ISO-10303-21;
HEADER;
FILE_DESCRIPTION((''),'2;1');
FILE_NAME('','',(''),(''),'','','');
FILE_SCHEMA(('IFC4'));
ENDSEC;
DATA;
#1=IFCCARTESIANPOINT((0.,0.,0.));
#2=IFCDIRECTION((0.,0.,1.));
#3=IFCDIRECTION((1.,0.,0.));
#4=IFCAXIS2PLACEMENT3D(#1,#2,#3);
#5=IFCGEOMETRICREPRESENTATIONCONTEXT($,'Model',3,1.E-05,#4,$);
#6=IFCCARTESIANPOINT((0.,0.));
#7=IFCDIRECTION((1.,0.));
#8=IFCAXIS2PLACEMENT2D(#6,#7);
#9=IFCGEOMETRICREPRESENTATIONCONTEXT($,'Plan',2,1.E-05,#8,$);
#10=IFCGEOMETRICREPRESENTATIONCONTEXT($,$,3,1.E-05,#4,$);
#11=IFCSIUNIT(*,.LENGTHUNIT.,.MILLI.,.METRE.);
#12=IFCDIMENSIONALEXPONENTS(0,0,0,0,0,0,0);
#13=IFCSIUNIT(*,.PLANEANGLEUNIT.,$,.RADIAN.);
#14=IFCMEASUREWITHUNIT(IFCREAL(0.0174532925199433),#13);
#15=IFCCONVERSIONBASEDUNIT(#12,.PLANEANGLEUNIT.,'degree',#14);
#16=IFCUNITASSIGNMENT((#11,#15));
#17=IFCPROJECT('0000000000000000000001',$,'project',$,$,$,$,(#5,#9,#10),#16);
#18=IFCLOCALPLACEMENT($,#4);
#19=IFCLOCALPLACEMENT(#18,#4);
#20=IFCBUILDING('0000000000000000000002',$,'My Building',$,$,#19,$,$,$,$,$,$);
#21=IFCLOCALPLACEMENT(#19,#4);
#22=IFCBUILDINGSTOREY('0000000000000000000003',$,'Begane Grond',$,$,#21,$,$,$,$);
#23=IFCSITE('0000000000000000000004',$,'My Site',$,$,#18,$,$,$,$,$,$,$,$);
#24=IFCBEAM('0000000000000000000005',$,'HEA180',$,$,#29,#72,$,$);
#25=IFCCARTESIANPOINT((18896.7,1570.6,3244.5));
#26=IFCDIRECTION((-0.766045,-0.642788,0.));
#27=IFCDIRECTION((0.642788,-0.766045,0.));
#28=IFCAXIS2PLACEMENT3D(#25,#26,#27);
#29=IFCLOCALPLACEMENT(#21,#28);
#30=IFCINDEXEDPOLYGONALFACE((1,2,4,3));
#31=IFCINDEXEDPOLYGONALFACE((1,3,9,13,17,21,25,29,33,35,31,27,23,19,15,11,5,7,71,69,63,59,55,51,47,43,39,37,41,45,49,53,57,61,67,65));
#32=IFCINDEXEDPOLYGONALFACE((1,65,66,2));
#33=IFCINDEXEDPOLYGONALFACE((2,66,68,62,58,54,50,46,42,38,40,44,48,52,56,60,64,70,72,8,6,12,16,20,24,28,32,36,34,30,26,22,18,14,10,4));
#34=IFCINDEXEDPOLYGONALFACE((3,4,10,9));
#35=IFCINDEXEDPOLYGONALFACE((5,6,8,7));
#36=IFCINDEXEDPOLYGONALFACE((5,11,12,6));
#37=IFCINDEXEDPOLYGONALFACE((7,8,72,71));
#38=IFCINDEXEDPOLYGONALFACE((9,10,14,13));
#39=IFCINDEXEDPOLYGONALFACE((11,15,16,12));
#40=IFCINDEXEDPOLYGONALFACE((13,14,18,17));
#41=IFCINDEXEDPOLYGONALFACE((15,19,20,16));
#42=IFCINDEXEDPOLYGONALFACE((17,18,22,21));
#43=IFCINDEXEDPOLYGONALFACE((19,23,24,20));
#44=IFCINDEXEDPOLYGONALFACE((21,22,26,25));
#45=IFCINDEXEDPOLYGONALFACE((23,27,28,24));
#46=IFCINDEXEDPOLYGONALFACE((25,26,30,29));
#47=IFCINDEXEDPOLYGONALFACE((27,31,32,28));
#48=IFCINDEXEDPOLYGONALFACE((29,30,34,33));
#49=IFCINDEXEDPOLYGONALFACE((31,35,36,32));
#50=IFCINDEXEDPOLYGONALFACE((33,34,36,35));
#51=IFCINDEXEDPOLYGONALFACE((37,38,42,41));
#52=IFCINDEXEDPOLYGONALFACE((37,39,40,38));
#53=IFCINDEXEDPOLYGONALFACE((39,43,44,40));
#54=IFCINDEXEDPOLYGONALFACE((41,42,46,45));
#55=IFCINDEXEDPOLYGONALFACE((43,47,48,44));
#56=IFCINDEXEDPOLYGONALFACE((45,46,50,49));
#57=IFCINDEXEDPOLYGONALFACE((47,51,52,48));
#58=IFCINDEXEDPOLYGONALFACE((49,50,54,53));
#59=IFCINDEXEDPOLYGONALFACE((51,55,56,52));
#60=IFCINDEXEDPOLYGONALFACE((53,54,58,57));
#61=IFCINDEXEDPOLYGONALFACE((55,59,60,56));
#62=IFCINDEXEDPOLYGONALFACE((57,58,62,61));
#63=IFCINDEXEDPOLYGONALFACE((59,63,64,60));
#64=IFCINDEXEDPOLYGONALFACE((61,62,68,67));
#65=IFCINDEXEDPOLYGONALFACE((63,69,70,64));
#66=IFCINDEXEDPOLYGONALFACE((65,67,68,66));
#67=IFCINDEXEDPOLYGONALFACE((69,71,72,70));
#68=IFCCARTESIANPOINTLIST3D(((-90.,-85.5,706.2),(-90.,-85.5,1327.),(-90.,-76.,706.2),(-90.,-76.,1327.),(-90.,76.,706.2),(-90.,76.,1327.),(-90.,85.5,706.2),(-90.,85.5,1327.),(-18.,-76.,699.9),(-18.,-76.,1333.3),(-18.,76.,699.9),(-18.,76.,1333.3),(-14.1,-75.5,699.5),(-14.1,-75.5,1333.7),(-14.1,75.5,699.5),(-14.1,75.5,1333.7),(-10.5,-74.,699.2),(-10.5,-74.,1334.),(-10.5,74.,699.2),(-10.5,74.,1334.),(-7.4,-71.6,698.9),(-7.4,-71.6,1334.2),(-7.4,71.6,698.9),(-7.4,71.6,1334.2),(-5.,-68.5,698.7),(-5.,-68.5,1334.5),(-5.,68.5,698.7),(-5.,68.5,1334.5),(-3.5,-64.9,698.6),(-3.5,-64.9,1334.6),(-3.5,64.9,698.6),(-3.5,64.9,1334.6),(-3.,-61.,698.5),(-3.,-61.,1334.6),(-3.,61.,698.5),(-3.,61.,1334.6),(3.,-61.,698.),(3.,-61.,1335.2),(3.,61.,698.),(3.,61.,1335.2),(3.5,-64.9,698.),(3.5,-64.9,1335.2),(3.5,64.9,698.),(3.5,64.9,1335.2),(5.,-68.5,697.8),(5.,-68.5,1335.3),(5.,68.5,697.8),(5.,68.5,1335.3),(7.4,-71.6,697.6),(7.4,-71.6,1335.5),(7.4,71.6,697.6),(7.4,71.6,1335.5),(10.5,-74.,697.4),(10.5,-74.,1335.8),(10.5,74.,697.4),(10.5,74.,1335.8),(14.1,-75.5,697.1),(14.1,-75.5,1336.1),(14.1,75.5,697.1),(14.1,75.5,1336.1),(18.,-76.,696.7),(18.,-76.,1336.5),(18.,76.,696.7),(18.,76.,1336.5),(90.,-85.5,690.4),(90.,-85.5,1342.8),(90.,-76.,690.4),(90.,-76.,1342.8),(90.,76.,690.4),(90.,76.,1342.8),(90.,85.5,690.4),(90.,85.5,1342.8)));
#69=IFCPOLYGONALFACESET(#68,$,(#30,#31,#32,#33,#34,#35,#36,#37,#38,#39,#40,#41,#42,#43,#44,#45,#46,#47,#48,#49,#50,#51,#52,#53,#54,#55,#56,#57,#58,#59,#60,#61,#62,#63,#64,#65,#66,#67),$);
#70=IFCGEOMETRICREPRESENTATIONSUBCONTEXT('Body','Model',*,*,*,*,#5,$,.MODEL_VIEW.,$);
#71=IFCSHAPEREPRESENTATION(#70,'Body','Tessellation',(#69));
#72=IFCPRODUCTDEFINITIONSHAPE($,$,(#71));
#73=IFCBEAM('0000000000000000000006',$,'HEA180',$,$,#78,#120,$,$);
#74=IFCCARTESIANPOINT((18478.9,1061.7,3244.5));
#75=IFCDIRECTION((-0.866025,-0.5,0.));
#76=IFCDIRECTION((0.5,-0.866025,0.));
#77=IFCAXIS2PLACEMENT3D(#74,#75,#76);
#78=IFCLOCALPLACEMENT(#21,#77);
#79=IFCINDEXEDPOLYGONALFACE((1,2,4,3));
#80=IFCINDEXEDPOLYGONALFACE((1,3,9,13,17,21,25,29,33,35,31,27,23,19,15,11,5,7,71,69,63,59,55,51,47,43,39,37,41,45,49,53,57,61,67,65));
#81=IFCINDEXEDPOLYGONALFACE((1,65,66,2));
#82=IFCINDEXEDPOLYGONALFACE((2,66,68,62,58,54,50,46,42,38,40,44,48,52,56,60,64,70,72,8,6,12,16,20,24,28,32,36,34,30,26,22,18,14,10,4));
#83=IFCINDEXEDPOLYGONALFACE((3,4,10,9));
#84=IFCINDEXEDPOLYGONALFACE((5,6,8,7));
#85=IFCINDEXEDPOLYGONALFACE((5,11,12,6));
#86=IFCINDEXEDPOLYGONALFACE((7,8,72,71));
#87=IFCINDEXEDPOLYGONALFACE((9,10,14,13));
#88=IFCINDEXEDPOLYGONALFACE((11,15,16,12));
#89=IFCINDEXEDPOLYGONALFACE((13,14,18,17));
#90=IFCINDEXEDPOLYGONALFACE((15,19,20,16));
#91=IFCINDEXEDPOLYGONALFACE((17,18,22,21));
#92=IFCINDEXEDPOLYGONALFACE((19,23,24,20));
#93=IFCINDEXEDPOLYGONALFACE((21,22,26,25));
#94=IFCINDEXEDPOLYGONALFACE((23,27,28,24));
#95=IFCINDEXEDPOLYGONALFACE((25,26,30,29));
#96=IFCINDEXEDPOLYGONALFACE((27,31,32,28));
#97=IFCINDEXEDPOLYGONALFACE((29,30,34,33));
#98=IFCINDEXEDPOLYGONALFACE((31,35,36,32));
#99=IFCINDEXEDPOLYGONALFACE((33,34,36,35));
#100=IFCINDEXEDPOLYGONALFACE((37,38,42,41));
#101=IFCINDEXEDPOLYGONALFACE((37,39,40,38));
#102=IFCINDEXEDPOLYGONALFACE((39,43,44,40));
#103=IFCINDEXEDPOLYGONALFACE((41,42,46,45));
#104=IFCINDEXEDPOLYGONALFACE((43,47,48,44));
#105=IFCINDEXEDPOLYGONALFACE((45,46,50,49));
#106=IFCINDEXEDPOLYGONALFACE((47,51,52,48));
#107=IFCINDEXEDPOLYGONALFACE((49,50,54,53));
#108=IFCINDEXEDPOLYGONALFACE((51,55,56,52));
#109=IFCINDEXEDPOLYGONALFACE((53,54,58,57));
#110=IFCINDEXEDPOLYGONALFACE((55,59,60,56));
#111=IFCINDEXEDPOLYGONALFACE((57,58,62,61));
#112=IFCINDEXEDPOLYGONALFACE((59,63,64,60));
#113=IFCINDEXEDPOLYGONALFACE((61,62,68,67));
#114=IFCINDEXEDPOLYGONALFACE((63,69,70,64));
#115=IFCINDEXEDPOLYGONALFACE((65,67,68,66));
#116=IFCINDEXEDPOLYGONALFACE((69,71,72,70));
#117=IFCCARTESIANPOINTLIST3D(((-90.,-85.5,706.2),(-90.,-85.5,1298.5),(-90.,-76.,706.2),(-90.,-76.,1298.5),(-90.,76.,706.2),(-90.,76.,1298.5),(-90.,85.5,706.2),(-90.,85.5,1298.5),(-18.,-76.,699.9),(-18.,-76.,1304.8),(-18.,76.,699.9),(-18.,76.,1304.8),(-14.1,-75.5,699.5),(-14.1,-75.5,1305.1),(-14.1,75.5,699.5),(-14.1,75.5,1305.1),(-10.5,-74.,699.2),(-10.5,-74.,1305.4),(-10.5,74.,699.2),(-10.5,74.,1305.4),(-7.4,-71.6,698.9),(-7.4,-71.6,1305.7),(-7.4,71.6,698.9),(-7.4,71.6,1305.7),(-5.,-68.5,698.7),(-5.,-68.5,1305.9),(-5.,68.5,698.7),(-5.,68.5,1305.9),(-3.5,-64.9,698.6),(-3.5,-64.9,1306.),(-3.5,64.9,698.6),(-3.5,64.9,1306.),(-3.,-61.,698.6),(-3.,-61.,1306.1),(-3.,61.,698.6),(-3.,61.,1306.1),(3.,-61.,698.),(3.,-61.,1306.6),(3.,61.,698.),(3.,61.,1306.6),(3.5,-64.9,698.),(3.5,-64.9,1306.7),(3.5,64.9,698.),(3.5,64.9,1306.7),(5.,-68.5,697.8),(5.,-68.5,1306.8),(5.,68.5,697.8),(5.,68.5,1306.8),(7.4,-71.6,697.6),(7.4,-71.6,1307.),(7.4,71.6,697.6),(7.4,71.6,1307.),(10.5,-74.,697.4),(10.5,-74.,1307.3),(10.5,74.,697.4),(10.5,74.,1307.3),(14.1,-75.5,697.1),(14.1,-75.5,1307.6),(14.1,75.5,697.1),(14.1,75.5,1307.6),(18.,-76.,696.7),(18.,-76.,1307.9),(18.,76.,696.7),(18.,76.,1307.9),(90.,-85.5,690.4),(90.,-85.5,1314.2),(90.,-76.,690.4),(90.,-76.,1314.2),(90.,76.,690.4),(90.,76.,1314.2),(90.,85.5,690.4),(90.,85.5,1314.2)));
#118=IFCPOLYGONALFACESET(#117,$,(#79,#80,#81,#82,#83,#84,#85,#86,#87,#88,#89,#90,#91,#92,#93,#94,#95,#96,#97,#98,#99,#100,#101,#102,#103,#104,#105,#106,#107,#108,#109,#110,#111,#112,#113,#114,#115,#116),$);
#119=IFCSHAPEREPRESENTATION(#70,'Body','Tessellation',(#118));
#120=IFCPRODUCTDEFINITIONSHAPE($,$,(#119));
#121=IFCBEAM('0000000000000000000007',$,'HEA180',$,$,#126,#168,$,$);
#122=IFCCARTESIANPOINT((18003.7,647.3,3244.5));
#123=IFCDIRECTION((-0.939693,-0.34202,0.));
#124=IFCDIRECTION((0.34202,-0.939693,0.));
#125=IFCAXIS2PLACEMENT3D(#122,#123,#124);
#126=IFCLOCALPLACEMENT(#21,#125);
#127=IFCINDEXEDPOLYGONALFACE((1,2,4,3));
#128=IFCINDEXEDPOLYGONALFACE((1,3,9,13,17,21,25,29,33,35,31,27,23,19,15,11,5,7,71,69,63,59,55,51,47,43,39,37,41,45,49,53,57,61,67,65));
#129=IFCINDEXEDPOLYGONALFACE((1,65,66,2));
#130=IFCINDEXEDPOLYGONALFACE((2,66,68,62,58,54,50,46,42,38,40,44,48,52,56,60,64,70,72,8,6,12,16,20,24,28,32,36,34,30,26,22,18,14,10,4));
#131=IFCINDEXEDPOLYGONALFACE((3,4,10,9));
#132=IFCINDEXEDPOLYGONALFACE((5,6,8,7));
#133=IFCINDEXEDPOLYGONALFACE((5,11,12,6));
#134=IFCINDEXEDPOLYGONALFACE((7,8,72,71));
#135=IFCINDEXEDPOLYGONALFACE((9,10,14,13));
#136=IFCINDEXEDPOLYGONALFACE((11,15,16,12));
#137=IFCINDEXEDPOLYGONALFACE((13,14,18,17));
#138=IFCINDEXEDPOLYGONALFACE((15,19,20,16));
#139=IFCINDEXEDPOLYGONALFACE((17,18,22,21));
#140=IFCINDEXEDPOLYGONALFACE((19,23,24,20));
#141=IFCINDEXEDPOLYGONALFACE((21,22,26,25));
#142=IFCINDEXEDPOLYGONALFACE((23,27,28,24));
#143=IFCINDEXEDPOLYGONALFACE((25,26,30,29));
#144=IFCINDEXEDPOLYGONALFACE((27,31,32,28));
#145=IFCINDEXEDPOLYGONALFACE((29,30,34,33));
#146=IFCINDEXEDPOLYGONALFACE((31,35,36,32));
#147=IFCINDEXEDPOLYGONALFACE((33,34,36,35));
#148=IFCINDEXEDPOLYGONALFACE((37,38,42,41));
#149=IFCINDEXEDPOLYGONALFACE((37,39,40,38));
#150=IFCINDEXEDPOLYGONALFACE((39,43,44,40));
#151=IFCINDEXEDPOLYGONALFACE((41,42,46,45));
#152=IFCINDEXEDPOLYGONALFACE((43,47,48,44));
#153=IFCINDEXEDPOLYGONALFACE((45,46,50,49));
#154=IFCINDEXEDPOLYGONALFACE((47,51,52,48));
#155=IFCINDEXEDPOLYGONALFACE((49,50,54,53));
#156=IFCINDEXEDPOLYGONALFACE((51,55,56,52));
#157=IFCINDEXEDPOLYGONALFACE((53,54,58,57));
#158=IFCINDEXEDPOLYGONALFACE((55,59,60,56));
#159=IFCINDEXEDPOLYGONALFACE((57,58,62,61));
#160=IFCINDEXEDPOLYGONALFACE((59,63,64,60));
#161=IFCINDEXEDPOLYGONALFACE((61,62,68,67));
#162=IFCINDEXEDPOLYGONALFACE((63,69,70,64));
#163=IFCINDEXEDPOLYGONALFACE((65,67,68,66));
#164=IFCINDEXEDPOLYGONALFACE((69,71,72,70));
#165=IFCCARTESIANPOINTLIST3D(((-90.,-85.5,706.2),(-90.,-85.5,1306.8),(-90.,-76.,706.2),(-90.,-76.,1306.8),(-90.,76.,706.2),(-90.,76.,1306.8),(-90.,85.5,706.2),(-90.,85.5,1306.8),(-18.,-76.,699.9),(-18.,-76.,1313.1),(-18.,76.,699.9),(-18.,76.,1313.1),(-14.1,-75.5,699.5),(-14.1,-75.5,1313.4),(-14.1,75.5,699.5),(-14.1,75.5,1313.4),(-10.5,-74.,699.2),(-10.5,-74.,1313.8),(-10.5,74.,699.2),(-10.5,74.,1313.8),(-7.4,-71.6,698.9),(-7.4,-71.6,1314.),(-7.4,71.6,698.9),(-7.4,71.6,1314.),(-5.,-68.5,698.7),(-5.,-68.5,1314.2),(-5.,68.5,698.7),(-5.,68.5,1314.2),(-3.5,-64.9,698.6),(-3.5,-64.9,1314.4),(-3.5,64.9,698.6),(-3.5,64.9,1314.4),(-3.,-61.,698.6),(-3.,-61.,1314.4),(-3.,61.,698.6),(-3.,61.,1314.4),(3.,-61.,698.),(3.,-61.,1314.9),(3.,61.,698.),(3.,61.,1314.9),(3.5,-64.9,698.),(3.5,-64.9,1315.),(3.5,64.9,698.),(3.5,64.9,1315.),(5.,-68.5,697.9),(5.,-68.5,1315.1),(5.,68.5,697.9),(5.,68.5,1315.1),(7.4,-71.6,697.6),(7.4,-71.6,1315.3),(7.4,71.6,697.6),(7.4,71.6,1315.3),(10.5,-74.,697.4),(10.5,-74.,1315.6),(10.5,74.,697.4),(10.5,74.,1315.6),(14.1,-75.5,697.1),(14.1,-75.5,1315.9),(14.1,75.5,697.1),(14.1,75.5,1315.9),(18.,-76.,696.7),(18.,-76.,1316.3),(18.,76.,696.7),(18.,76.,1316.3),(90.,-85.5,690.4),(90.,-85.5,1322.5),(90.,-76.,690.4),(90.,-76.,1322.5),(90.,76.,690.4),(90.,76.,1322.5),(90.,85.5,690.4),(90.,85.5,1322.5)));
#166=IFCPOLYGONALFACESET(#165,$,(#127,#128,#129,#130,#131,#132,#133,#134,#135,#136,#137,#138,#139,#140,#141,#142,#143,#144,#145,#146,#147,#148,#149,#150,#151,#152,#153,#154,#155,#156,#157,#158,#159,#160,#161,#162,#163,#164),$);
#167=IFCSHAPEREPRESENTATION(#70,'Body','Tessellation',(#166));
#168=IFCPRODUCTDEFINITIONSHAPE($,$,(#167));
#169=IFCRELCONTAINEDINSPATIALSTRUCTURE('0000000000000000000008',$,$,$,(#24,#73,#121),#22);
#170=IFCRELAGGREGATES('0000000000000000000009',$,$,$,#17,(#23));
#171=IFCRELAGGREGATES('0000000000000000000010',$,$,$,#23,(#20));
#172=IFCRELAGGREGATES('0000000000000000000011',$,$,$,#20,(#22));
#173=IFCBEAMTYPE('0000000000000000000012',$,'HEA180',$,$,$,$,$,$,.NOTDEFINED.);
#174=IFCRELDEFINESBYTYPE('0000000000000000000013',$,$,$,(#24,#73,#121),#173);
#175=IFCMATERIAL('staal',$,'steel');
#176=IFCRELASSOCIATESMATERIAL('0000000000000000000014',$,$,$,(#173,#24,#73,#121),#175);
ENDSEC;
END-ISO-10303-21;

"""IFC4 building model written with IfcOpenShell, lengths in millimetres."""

from ifc_helpers import new_model, entity, si_unit, converted_unit, frame, origin_with_axes, origin_2d_with_axis, place, context, subcontext, project, spatial, i_section, extrude, clip, halfspace, material, material_profile, profile_set, profile_usage, type_object, element, save


model = new_model("IFC4")

# Units and contexts
model_context = context("Model", 3, precision=1e-05, world=origin_with_axes())
plan_context = context("Plan", 2, precision=1e-05, world=origin_2d_with_axis())
context_of_model = context(None, 3, precision=1e-05, world=origin_with_axes())
body_context = subcontext(model_context, "Body", "Model", "MODEL_VIEW")
ifc_project = project(units=[si_unit("LENGTHUNIT", "METRE", prefix="MILLI"), converted_unit("PLANEANGLEUNIT", "degree", entity("IfcReal", 0.0174532925199433), si_unit("PLANEANGLEUNIT", "RADIAN"), dimensions=[0, 0, 0, 0, 0, 0, 0])], contexts=[model_context, plan_context, context_of_model])

# Site, building, storey
site_placement = place(None, origin_with_axes())
site = spatial("IfcSite", under=ifc_project, at=site_placement, Name="My Site")
building_placement = place(site_placement, origin_with_axes())
building = spatial("IfcBuilding", under=site, at=building_placement, Name="My Building")
storey_placement = place(building_placement, origin_with_axes())
storey = spatial("IfcBuildingStorey", under=building, at=storey_placement, Name="Begane Grond")

# Shared definitions
ifc_material = material(Name="staal", Category="steel")

# Beams
ifc_material_profile_1 = material_profile(ifc_material, i_section(OverallWidth=180.0, OverallDepth=171.0, WebThickness=6.0, FlangeThickness=9.5, FilletRadius=15.0))
ifc_profile_set_1 = profile_set([ifc_material_profile_1], Name="HEA180")
beam_type_1 = type_object("IfcBeamType", Name="HEA180", PredefinedType="NOTDEFINED", material=ifc_profile_set_1)
ifc_profile_usage_1 = profile_usage(ifc_profile_set_1)
beam_1_placement = place(storey_placement, frame((18896.7, 1570.6, 3244.5), z_axis=(-0.766045, -0.642788, 0.0), x_axis=(0.642788, -0.766045, 0.0)))
element("IfcBeam", 1, at=beam_1_placement, inside=storey, type_object=beam_type_1, material=ifc_profile_usage_1, Name="HEA180", context=body_context, shape_type="Clipping", body=[
    clip(clip(extrude(i_section(OverallWidth=180.0, OverallDepth=171.0, WebThickness=6.0, FlangeThickness=9.5, FilletRadius=15.0), origin_with_axes(), (0.0, 0.0, 1.0), 2033.2), halfspace(frame((90.0, -3254.0, 690.4), z_axis=(-0.087118, 0.0, -0.996198), x_axis=(0.000001, 1.0, 0.0)), False)), halfspace(frame((90.0, -3254.0, 1342.8), z_axis=(-0.087142, 0.0, 0.996196), x_axis=(0.000003, 1.0, 0.0)), False)),
])
ifc_profile_usage_2 = profile_usage(ifc_profile_set_1)
beam_2_placement = place(storey_placement, frame((18478.9, 1061.7, 3244.5), z_axis=(-0.866025, -0.5, 0.0), x_axis=(0.5, -0.866025, 0.0)))
element("IfcBeam", 2, at=beam_2_placement, inside=storey, type_object=beam_type_1, material=ifc_profile_usage_2, Name="HEA180", context=body_context, shape_type="Clipping", body=[
    clip(clip(extrude(i_section(OverallWidth=180.0, OverallDepth=171.0, WebThickness=6.0, FlangeThickness=9.5, FilletRadius=15.0), origin_with_axes(), (0.0, 0.0, 1.0), 2004.6), halfspace(frame((90.0, -3235.0, 690.4), z_axis=(-0.087185, 0.0, -0.996192), x_axis=(-0.000003, 1.0, 0.0)), False)), halfspace(frame((90.0, -3235.0, 1314.2), z_axis=(-0.087181, -0.000001, 0.996192), x_axis=(-0.000007, 1.0, 0.0)), False)),
])
ifc_profile_usage_3 = profile_usage(ifc_profile_set_1)
beam_3_placement = place(storey_placement, frame((18003.7, 647.3, 3244.5), z_axis=(-0.939693, -0.34202, 0.0), x_axis=(0.34202, -0.939693, 0.0)))
element("IfcBeam", 3, at=beam_3_placement, inside=storey, type_object=beam_type_1, material=ifc_profile_usage_3, Name="HEA180", context=body_context, shape_type="Clipping", body=[
    clip(clip(extrude(i_section(OverallWidth=180.0, OverallDepth=171.0, WebThickness=6.0, FlangeThickness=9.5, FilletRadius=15.0), origin_with_axes(), (0.0, 0.0, 1.0), 2013.0), halfspace(frame((90.0, -3244.5, 690.4), z_axis=(-0.087145, 0.000001, -0.996196), x_axis=(0.000007, 1.0, 0.0)), False)), halfspace(frame((90.0, -3244.5, 1322.5), z_axis=(-0.08715, 0.0, 0.996195), x_axis=(0.000001, 1.0, 0.0)), False)),
])

save(model, "model.ifc")
